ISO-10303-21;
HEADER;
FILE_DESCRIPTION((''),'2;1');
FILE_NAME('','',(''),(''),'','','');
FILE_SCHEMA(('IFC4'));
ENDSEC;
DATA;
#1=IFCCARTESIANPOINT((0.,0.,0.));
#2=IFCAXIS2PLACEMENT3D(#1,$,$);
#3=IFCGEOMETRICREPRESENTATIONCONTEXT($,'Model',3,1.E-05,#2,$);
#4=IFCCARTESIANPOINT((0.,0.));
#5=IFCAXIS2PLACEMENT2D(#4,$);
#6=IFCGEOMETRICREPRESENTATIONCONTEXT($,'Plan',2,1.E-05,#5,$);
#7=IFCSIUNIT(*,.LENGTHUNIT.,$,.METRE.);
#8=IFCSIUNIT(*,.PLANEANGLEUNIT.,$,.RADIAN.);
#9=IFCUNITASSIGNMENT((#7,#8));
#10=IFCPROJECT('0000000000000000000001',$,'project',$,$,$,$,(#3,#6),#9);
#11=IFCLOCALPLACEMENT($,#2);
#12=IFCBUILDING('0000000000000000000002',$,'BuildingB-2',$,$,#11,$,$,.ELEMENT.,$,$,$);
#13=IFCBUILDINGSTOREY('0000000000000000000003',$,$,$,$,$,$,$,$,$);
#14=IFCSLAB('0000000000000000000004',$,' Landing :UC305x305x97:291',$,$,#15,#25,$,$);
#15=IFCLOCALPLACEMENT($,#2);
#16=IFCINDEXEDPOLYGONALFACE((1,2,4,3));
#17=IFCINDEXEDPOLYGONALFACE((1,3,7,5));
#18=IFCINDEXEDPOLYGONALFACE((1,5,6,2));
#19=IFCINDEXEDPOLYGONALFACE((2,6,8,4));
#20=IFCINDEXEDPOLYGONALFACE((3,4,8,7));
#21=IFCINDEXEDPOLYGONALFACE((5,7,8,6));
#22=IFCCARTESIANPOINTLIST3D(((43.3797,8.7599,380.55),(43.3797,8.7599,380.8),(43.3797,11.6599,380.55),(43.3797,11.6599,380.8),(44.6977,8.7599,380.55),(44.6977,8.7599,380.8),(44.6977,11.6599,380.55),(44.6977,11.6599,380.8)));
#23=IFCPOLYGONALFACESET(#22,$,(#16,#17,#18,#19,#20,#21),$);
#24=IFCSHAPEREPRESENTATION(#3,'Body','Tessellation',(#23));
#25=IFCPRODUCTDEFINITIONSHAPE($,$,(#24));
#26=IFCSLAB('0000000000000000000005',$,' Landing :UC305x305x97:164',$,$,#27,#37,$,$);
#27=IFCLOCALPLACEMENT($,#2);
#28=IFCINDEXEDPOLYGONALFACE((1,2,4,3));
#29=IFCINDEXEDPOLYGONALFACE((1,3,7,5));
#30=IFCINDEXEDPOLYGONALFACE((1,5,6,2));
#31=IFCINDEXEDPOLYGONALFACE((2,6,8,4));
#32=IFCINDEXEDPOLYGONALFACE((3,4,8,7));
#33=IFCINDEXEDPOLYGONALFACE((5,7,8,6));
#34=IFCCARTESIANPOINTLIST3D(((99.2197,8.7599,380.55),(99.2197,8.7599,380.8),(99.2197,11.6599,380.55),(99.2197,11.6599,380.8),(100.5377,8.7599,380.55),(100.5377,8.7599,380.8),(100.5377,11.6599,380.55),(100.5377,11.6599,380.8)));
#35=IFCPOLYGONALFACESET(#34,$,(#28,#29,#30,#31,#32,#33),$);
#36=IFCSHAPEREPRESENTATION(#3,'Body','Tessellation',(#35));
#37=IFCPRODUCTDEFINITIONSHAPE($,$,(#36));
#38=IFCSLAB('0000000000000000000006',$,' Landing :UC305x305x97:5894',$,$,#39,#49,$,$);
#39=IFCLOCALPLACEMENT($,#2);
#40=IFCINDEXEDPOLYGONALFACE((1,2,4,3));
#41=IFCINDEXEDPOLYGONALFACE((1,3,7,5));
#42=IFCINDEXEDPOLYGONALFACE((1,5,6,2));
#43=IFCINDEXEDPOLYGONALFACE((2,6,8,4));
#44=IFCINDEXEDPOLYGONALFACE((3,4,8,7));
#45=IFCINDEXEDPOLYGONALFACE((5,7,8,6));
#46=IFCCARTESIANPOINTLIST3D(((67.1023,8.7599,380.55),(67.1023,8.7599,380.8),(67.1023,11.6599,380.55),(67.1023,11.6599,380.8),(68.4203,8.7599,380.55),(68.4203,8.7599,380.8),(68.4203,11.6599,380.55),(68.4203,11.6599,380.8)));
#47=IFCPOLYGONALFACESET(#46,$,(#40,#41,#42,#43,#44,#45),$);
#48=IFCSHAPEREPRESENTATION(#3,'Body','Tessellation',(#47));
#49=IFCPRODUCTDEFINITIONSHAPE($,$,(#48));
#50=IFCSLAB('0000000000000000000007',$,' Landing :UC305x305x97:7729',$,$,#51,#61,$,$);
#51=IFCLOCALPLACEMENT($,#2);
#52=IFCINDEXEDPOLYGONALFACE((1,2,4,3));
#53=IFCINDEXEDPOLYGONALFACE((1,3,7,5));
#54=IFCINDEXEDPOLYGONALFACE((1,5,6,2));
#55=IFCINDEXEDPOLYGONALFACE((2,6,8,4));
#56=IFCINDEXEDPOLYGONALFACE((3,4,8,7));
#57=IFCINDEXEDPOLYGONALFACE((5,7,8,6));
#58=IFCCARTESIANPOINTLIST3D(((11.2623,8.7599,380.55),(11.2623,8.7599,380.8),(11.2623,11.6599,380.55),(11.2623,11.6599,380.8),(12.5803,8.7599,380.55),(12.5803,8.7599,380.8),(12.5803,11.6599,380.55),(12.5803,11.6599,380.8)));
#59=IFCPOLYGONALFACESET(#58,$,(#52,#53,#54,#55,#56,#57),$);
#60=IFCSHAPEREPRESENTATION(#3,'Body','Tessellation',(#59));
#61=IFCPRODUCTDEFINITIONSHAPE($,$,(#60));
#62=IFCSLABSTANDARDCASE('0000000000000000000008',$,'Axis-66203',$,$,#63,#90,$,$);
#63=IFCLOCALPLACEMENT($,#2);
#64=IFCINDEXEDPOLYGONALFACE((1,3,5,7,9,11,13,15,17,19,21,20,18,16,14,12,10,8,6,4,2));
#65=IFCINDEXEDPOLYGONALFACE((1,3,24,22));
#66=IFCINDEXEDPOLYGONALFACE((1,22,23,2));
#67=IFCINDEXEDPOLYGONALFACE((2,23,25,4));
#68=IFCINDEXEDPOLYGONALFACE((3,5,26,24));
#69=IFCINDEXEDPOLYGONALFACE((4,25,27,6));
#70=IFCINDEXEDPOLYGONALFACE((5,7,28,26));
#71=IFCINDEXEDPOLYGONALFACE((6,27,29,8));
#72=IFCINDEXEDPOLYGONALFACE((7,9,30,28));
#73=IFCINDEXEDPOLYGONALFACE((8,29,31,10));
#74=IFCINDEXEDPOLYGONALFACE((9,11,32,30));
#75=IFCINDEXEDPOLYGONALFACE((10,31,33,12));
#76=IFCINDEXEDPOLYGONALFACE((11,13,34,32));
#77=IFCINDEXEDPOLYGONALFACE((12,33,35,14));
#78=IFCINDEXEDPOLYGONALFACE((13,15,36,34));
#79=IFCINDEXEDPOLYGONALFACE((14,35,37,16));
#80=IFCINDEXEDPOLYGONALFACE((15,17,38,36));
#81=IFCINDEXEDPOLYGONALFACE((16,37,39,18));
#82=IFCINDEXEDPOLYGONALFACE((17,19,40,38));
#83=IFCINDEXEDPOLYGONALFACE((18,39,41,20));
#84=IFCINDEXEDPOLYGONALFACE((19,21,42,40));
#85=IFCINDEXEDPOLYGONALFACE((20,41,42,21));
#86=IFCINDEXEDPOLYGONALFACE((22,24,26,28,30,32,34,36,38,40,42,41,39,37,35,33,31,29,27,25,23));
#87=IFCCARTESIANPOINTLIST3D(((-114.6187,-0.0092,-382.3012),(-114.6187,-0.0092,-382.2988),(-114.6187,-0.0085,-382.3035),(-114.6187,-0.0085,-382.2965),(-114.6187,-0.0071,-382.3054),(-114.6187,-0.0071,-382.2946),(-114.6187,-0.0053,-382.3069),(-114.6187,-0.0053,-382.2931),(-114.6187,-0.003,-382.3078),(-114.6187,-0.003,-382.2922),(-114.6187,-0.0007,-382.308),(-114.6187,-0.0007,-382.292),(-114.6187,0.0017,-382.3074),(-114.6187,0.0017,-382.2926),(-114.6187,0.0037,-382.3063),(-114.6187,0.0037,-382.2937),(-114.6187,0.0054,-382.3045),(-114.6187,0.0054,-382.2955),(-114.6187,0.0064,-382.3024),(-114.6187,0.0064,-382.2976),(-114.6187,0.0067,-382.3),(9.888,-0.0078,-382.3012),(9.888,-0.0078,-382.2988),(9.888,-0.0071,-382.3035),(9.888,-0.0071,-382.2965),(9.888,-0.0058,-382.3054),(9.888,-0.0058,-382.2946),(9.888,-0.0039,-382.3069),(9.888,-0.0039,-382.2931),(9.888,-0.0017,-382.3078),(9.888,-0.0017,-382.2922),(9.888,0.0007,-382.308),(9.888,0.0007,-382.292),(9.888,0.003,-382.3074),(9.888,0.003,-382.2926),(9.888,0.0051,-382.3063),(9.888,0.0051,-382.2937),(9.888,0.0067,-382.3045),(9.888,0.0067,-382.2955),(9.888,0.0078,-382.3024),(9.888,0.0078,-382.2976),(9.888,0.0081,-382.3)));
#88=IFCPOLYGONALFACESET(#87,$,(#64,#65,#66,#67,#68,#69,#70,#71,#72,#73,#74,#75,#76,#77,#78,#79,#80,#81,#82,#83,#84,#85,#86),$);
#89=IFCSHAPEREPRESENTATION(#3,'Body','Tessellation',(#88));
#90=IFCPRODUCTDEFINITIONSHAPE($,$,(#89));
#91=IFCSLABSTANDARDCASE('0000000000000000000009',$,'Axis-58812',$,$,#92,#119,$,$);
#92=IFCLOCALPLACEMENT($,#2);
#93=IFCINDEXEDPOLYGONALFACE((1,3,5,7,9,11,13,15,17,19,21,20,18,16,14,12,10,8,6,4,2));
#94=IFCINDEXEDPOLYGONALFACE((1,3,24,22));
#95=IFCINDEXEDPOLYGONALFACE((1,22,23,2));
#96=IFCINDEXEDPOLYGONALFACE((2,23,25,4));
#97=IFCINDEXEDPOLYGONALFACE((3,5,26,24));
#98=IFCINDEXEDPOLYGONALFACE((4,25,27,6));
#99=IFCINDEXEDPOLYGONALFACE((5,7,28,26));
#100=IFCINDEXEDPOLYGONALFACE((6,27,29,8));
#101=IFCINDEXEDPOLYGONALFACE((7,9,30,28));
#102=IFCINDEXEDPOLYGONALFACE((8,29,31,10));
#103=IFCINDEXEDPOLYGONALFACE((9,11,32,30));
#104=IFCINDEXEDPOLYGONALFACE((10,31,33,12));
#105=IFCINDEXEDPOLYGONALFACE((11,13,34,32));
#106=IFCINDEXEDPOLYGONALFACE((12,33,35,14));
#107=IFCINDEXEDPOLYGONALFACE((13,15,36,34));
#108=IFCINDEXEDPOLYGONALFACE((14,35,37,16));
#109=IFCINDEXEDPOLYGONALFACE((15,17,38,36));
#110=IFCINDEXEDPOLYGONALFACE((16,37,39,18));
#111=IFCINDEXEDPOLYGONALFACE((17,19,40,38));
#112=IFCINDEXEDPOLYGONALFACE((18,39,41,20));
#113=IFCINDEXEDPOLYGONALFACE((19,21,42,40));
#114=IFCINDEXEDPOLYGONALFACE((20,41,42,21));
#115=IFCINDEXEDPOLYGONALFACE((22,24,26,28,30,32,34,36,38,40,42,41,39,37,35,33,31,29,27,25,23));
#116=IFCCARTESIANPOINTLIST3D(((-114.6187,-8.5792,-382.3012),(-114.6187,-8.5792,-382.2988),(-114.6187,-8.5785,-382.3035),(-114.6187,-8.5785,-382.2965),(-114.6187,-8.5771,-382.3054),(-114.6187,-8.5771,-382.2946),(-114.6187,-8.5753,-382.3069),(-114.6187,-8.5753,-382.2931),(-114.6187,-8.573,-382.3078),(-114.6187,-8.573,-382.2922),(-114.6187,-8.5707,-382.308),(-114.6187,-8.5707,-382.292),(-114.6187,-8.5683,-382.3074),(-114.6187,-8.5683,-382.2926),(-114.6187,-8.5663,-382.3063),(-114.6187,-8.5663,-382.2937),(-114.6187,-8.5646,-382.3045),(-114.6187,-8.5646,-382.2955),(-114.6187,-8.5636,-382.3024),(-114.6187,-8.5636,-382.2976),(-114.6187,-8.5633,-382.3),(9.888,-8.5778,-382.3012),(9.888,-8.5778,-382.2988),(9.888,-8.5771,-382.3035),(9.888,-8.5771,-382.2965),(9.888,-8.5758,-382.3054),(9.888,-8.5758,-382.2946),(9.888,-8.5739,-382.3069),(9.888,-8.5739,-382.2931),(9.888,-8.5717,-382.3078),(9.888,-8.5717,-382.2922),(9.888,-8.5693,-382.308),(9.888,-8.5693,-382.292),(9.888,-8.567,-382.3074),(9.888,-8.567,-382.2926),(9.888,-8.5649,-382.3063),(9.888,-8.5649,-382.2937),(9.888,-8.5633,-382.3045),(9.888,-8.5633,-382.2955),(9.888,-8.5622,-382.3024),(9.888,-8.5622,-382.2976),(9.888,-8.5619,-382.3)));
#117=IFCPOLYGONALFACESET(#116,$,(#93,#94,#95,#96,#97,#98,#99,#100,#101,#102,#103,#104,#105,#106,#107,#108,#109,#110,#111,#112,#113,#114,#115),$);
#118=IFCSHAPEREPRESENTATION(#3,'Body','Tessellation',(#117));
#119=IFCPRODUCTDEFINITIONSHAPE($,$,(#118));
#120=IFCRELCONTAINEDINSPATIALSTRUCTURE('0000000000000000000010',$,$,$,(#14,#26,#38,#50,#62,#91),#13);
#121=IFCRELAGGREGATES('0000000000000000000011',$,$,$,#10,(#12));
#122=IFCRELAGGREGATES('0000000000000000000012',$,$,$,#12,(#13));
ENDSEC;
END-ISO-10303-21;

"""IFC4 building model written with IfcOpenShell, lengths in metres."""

from ifc_helpers import new_model, entity, si_unit, origin, origin_2d, place, context, project, spatial, polyline, outline, extrude, element, save


model = new_model("IFC4")

# Units and contexts
model_context = context("Model", 3, precision=1e-05, world=origin())
plan_context = context("Plan", 2, precision=1e-05, world=origin_2d())
ifc_project = project(units=[si_unit("LENGTHUNIT", "METRE"), si_unit("PLANEANGLEUNIT", "RADIAN")], contexts=[model_context, plan_context])

# Building, storey
building_placement = place(None, origin())
building = spatial("IfcBuilding", under=ifc_project, at=building_placement, Name="BuildingB-2", CompositionType="ELEMENT")
storey = spatial("IfcBuildingStorey", under=building)

# Slabs
element("IfcSlab", 1, inside=storey, Name=" Landing :UC305x305x97:291", context=model_context, shape_type="SweptSolid", body=[
    extrude(outline(polyline([(44.6977, 11.6599, 380.8), (44.6977, 8.7599, 380.8), (43.3797, 8.7599, 380.8), (43.3797, 11.6599, 380.8), (44.6977, 11.6599, 380.8)])), None, (0.0, 0.0, -1.0), 0.25),
])
element("IfcSlab", 2, inside=storey, Name=" Landing :UC305x305x97:164", context=model_context, shape_type="SweptSolid", body=[
    extrude(outline(polyline([(100.5377, 11.6599, 380.8), (100.5377, 8.7599, 380.8), (99.2197, 8.7599, 380.8), (99.2197, 11.6599, 380.8), (100.5377, 11.6599, 380.8)])), None, (0.0, 0.0, -1.0), 0.25),
])
element("IfcSlab", 3, inside=storey, Name=" Landing :UC305x305x97:5894", context=model_context, shape_type="SweptSolid", body=[
    extrude(outline(polyline([(67.1023, 11.6599, 380.8), (67.1023, 8.7599, 380.8), (68.4203, 8.7599, 380.8), (68.4203, 11.6599, 380.8), (67.1023, 11.6599, 380.8)])), None, (0.0, 0.0, -1.0), 0.25),
])
element("IfcSlab", 4, inside=storey, Name=" Landing :UC305x305x97:7729", context=model_context, shape_type="SweptSolid", body=[
    extrude(outline(polyline([(11.2623, 11.6599, 380.8), (11.2623, 8.7599, 380.8), (12.5803, 8.7599, 380.8), (12.5803, 11.6599, 380.8), (11.2623, 11.6599, 380.8)])), None, (0.0, 0.0, -1.0), 0.25),
])
element("IfcSlabStandardCase", 5, inside=storey, Name="Axis-66203", context=model_context, shape_type="AdvancedSweptSolid", body=[
    entity("IfcSurfaceCurveSweptAreaSolid", entity("IfcCircleProfileDef", "AREA", None, None, 0.008), None, entity("IfcPolyline", [entity("IfcCartesianPoint", [-9.888, -0.0001, 382.3]), entity("IfcCartesianPoint", [114.6187, 0.0013, 382.3])]), None, None, entity("IfcPlane", entity("IfcAxis2Placement3D", entity("IfcCartesianPoint", [-9.888, -0.0001, 382.3]), entity("IfcDirection", [0.0, 0.0, 1.0]), entity("IfcDirection", [1.0, 0.0, 0.0])))),
    entity("IfcSurfaceCurveSweptAreaSolid", entity("IfcCircleProfileDef", "AREA", None, None, 0.008), None, entity("IfcCircle", entity("IfcAxis2Placement2D", entity("IfcCartesianPoint", [-10.1215, -0.0001, 382.3])), 0.35), None, None, entity("IfcPlane", entity("IfcAxis2Placement3D", entity("IfcCartesianPoint", [-10.1215, -0.0001, 382.3]), entity("IfcDirection", [0.0, 0.0, 1.0]), entity("IfcDirection", [1.0, 0.0, 0.0])))),
    entity("IfcSurfaceCurveSweptAreaSolid", entity("IfcCircleProfileDef", "AREA", None, None, 0.008), None, entity("IfcCircle", entity("IfcAxis2Placement2D", entity("IfcCartesianPoint", [114.8522, 0.0013, 382.3])), 0.35), None, None, entity("IfcPlane", entity("IfcAxis2Placement3D", entity("IfcCartesianPoint", [114.8522, 0.0013, 382.3]), entity("IfcDirection", [0.0, 0.0, 1.0]), entity("IfcDirection", [1.0, 0.0, 0.0])))),
])
element("IfcSlabStandardCase", 6, inside=storey, Name="Axis-58812", context=model_context, shape_type="AdvancedSweptSolid", body=[
    entity("IfcSurfaceCurveSweptAreaSolid", entity("IfcCircleProfileDef", "AREA", None, None, 0.008), None, entity("IfcPolyline", [entity("IfcCartesianPoint", [-9.888, 8.5699, 382.3]), entity("IfcCartesianPoint", [114.6187, 8.5713, 382.3])]), None, None, entity("IfcPlane", entity("IfcAxis2Placement3D", entity("IfcCartesianPoint", [-9.888, 8.5699, 382.3]), entity("IfcDirection", [0.0, 0.0, 1.0]), entity("IfcDirection", [1.0, 0.0, 0.0])))),
    entity("IfcSurfaceCurveSweptAreaSolid", entity("IfcCircleProfileDef", "AREA", None, None, 0.008), None, entity("IfcCircle", entity("IfcAxis2Placement2D", entity("IfcCartesianPoint", [-10.1215, 8.5699, 382.3])), 0.35), None, None, entity("IfcPlane", entity("IfcAxis2Placement3D", entity("IfcCartesianPoint", [-10.1215, 8.5699, 382.3]), entity("IfcDirection", [0.0, 0.0, 1.0]), entity("IfcDirection", [1.0, 0.0, 0.0])))),
    entity("IfcSurfaceCurveSweptAreaSolid", entity("IfcCircleProfileDef", "AREA", None, None, 0.008), None, entity("IfcCircle", entity("IfcAxis2Placement2D", entity("IfcCartesianPoint", [114.8522, 8.5713, 382.3])), 0.35), None, None, entity("IfcPlane", entity("IfcAxis2Placement3D", entity("IfcCartesianPoint", [114.8522, 8.5713, 382.3]), entity("IfcDirection", [0.0, 0.0, 1.0]), entity("IfcDirection", [1.0, 0.0, 0.0])))),
])

save(model, "model.ifc")
